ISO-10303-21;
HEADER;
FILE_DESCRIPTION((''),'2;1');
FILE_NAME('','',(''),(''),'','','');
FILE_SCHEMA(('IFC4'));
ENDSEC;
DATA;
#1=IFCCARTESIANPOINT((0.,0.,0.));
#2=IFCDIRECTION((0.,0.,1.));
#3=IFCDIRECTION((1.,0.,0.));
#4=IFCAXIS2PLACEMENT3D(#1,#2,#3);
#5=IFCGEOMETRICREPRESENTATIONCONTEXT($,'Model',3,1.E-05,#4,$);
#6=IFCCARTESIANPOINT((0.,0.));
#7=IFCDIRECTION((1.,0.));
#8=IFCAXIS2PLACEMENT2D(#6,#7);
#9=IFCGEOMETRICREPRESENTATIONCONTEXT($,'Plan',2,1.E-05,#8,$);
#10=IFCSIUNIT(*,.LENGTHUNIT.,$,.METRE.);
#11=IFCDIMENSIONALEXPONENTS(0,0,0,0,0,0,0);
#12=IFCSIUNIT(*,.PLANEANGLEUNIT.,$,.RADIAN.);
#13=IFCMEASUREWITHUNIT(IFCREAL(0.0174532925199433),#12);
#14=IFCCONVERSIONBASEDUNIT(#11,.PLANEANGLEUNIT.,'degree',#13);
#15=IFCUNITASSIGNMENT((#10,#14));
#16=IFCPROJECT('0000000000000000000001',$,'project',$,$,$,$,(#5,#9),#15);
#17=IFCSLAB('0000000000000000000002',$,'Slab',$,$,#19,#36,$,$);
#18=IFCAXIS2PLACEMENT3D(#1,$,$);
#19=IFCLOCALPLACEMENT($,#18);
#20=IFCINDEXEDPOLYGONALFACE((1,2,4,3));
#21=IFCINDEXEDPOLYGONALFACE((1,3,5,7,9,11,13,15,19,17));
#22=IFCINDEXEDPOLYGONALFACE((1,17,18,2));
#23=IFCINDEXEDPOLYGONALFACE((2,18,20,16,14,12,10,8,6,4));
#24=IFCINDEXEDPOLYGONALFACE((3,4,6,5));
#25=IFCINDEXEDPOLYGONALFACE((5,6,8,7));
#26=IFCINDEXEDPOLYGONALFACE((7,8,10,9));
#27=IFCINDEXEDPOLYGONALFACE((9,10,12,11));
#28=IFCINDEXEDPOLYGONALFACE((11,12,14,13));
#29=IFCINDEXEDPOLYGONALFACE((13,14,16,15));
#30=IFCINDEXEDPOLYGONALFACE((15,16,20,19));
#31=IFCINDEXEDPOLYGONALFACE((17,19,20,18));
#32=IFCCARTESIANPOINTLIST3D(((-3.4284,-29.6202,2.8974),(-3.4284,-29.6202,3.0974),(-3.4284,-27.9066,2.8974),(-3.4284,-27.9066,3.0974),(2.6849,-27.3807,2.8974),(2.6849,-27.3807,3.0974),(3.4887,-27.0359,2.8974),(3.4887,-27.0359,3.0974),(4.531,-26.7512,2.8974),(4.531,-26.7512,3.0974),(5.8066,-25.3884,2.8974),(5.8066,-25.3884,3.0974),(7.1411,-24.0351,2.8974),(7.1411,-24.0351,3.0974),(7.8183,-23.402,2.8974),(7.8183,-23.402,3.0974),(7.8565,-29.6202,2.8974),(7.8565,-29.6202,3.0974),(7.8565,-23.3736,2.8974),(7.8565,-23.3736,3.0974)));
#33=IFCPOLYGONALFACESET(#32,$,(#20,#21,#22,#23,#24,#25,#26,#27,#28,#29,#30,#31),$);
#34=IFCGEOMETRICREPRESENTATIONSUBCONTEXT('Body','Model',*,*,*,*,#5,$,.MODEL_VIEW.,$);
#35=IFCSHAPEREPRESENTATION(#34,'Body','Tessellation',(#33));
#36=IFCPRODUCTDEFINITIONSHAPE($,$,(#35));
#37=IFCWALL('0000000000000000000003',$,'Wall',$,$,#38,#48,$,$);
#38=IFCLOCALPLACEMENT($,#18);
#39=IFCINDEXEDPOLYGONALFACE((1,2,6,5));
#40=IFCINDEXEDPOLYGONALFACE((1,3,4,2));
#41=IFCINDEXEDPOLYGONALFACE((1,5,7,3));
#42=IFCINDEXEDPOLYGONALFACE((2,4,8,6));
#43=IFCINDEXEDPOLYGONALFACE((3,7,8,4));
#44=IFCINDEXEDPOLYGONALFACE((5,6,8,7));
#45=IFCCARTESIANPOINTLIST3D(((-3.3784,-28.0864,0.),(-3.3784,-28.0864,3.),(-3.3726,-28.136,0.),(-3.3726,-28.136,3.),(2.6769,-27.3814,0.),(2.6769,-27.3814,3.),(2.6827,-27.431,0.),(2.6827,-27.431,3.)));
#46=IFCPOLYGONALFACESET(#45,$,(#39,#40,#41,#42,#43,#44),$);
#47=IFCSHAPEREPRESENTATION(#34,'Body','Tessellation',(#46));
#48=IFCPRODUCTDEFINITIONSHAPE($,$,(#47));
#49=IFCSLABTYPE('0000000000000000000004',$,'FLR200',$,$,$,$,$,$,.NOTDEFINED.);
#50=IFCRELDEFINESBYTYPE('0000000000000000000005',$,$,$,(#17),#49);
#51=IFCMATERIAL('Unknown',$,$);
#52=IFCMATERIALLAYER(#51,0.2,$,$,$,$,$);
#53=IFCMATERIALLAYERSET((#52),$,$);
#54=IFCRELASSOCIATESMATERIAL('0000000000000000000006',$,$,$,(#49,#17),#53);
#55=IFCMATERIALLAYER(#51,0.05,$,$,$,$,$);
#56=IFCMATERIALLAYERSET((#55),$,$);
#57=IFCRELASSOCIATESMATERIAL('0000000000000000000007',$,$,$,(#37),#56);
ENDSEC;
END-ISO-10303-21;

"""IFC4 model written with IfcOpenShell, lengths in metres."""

from ifc_helpers import new_model, entity, si_unit, converted_unit, frame, origin_with_axes, origin_2d_with_axis, place, context, subcontext, project, indexed_curve, outline, extrude, material, layer, layer_set, layer_usage, type_object, element, save


model = new_model("IFC4")

# Units and contexts
model_context = context("Model", 3, precision=1e-05, world=origin_with_axes())
plan_context = context("Plan", 2, precision=1e-05, world=origin_2d_with_axis())
body_context = subcontext(model_context, "Body", "Model", "MODEL_VIEW")
ifc_project = project(units=[si_unit("LENGTHUNIT", "METRE"), converted_unit("PLANEANGLEUNIT", "degree", entity("IfcReal", 0.0174532925199433), si_unit("PLANEANGLEUNIT", "RADIAN"), dimensions=[0, 0, 0, 0, 0, 0, 0])], contexts=[model_context, plan_context])

# Slab
ifc_material = material(Name="Unknown")
ifc_layer_1 = layer(ifc_material, 0.2)
ifc_layer_set_1 = layer_set([ifc_layer_1])
ifc_layer_usage_1 = layer_usage(ifc_layer_set_1, "AXIS3", "POSITIVE", -0.2)
slab_type = type_object("IfcSlabType", Name="FLR200", PredefinedType="NOTDEFINED", material=ifc_layer_set_1)
placement_1 = place(None, origin_with_axes())
placement_2 = place(placement_1, origin_with_axes())
placement_3 = place(placement_2, origin_with_axes())
slab_placement = place(placement_3, frame((-3.4284, -27.9066, 3.0974), z_axis=(0.0, 0.0, 1.0), x_axis=(1.0, 0.0, 0.0)))
element("IfcSlab", 1, at=slab_placement, type_object=slab_type, material=ifc_layer_usage_1, Name="Slab", context=body_context, shape_type="SweptSolid", body=[
    extrude(outline(indexed_curve([(6.1133, 0.5259), (6.9172, 0.8706), (7.9594, 1.1553), (9.235, 2.5182), (10.5695, 3.8715), (11.2467, 4.5046), (11.285, 4.533), (11.285, -1.7137), (0.0, -1.7137), (0.0, 0.0), (6.1133, 0.5259)])), frame((0.0, 0.0, -0.2), z_axis=(0.0, 0.0, 1.0), x_axis=(1.0, 0.0, 0.0)), (0.0, 0.0, 1.0), 0.2),
])

# Wall
ifc_layer_2 = layer(ifc_material, 0.05)
ifc_layer_set_2 = layer_set([ifc_layer_2])
ifc_layer_usage_2 = layer_usage(ifc_layer_set_2, "AXIS2", "POSITIVE", 0.0)
placement_4 = place(placement_2, origin_with_axes())
wall_placement = place(placement_4, frame((2.6769, -27.3814, 0.0), z_axis=(0.0, 0.0, 1.0), x_axis=(-0.99329, -0.115649, 0.0)))
element("IfcWall", 2, at=wall_placement, material=ifc_layer_usage_2, Name="Wall", context=body_context, shape_type="SweptSolid", body=[
    extrude(outline(indexed_curve([(0.0, 0.0), (0.0, 0.05), (6.0962, 0.05), (6.0962, 0.0), (0.0, 0.0)], self_intersect=False)), origin_with_axes(), (0.0, 0.0, 1.0), 3.0),
])

save(model, "model.ifc")
